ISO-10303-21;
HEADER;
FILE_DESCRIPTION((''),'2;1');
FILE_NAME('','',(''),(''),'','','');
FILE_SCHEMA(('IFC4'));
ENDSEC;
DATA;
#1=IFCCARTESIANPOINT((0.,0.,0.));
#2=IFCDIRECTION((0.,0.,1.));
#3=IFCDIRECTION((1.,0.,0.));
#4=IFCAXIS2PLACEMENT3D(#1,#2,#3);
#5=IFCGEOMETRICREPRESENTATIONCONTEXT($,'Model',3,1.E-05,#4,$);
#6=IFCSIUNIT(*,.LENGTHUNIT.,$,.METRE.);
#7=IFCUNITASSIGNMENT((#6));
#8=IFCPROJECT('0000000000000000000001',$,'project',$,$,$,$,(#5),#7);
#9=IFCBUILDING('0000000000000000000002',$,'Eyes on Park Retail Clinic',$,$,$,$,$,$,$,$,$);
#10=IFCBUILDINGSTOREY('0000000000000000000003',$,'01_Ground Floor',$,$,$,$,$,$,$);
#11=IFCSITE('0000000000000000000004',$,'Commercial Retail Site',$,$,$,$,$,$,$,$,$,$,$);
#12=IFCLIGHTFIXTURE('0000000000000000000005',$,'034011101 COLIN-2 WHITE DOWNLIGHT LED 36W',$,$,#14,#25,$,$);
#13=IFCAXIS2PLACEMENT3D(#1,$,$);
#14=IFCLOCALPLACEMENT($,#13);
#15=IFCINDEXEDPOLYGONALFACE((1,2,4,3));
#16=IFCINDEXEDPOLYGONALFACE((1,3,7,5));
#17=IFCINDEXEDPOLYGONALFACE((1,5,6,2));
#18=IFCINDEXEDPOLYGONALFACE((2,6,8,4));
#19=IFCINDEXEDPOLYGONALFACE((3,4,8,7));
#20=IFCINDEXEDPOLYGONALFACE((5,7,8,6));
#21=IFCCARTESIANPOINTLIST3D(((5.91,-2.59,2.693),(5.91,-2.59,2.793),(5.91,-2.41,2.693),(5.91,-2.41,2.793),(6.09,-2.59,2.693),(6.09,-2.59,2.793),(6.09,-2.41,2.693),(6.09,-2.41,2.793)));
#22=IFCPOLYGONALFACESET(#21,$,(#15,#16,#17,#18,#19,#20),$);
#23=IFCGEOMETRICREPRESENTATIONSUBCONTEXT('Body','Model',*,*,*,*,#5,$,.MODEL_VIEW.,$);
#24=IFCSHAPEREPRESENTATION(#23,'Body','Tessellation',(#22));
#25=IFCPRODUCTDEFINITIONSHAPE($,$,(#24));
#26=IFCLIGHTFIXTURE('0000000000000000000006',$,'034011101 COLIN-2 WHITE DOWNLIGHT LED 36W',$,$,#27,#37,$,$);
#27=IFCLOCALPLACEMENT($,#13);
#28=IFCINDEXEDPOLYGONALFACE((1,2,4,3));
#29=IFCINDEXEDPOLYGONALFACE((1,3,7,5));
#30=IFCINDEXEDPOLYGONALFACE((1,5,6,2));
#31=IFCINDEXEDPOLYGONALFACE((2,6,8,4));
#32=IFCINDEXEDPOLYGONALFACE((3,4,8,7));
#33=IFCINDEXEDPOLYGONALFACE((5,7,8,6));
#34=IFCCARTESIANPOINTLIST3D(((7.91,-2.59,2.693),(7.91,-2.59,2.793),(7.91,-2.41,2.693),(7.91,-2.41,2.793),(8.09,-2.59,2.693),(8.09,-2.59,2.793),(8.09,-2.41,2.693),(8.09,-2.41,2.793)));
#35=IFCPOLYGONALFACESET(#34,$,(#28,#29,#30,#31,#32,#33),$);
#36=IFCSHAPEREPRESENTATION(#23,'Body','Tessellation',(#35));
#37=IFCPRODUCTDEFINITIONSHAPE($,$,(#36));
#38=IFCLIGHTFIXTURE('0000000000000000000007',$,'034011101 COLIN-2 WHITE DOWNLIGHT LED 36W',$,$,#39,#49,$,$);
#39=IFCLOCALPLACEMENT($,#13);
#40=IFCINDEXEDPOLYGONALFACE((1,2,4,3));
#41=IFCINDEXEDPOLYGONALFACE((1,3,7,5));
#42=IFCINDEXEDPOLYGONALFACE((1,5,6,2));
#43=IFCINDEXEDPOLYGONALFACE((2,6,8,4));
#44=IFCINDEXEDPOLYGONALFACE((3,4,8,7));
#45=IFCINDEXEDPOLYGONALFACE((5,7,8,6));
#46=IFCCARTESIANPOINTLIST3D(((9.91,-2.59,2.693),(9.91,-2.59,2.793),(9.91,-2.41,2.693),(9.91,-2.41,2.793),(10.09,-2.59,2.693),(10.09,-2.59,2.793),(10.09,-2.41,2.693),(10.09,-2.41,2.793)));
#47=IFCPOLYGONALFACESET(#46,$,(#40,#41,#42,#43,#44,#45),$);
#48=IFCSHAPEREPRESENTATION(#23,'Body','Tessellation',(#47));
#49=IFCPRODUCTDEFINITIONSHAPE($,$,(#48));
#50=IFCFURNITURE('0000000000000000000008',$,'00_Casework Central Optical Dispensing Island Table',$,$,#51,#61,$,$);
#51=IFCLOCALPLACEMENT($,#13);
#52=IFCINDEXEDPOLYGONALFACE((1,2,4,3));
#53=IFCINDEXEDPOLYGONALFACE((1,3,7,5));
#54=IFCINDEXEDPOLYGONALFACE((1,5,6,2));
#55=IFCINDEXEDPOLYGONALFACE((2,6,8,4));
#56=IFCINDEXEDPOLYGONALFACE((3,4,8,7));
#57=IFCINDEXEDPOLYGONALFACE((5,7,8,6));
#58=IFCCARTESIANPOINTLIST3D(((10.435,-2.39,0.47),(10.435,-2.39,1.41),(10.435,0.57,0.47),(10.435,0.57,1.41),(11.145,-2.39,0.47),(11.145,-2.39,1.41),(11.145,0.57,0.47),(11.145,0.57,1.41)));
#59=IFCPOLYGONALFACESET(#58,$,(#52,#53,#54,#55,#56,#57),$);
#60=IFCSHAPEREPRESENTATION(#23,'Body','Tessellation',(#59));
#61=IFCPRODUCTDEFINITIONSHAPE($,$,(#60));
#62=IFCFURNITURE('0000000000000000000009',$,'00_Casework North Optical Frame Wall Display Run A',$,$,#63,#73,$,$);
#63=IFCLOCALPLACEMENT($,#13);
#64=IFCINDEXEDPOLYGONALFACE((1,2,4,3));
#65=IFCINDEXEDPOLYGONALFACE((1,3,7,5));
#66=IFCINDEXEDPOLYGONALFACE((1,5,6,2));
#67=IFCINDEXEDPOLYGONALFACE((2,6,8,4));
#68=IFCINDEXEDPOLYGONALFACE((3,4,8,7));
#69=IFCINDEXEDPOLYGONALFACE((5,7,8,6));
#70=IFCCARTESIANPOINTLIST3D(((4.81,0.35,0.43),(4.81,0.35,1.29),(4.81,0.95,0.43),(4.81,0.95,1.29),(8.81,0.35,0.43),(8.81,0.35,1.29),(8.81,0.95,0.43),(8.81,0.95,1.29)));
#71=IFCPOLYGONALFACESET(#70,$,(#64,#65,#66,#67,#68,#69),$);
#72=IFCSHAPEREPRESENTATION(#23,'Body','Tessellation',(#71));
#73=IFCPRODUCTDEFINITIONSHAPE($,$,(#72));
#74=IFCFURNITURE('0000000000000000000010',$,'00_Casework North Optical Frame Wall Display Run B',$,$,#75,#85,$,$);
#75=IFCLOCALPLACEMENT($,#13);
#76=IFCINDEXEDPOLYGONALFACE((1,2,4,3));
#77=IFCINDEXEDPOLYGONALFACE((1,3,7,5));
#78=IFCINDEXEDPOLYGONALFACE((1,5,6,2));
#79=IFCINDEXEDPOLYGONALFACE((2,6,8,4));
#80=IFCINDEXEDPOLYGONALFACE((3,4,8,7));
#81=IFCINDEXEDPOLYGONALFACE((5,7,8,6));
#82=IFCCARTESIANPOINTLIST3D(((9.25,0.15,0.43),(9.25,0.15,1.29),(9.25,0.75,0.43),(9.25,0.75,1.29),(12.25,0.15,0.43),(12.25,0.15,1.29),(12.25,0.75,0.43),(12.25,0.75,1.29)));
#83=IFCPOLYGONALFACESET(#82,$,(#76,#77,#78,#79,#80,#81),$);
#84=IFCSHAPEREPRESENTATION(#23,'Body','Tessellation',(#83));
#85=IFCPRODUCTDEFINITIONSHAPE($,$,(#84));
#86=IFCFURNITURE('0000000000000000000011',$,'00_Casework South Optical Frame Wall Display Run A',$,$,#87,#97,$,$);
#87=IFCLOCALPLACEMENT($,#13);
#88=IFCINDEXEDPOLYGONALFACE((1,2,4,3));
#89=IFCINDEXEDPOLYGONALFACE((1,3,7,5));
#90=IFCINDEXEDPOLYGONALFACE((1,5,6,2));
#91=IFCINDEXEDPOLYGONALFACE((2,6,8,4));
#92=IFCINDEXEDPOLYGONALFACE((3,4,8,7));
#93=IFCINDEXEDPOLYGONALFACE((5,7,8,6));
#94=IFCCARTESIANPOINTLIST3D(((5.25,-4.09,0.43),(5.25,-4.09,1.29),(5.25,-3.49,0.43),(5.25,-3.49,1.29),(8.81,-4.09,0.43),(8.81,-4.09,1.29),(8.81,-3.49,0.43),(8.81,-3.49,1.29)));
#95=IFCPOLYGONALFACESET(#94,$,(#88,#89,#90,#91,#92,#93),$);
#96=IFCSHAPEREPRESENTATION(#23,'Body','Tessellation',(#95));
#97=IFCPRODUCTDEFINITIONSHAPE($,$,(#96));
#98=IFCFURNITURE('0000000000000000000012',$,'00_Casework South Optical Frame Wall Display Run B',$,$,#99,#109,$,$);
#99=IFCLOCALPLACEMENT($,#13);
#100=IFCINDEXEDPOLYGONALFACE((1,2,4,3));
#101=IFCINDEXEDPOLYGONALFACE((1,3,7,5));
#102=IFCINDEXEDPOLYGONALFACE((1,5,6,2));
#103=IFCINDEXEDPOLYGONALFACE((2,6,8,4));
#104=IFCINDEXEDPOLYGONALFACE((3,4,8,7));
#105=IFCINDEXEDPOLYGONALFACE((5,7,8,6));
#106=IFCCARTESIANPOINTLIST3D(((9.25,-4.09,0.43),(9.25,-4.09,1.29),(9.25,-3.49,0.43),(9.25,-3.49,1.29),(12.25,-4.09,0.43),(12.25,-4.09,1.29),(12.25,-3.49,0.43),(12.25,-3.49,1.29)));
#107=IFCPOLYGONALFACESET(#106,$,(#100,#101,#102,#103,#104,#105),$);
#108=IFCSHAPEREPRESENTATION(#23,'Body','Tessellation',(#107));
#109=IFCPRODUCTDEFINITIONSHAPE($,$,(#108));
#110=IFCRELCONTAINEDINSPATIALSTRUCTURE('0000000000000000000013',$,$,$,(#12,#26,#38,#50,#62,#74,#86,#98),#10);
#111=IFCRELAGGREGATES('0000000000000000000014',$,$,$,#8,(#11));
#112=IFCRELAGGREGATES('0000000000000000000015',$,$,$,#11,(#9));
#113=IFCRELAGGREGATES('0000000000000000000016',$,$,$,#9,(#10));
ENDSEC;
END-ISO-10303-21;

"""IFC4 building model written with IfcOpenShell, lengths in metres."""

from ifc_helpers import new_model, si_unit, frame, origin, origin_with_axes, place, context, subcontext, project, spatial, rectangle, extrude, element, save


model = new_model("IFC4")

# Units and contexts
model_context = context("Model", 3, precision=1e-05, world=origin_with_axes())
body_context = subcontext(model_context, "Body", "Model", "MODEL_VIEW")
ifc_project = project(units=[si_unit("LENGTHUNIT", "METRE")], contexts=[model_context])

# Site, building, storey
site = spatial("IfcSite", under=ifc_project, Name="Commercial Retail Site")
building = spatial("IfcBuilding", under=site, Name="Eyes on Park Retail Clinic")
storey = spatial("IfcBuildingStorey", under=building, Name="01_Ground Floor")

# Light fixtures
for number, where, z_axis, x_axis, name in (
    (1, (6.0, -2.5, 2.693), (0.0, 0.0, 1.0), (1.0, 0.0, 0.0), "034011101 COLIN-2 WHITE DOWNLIGHT LED 36W"),
    (2, (8.0, -2.5, 2.693), (0.0, 0.0, 1.0), (1.0, 0.0, 0.0), "034011101 COLIN-2 WHITE DOWNLIGHT LED 36W"),
    (3, (10.0, -2.5, 2.693), (0.0, 0.0, 1.0), (1.0, 0.0, 0.0), "034011101 COLIN-2 WHITE DOWNLIGHT LED 36W"),
):
    element("IfcLightFixture", number, at=place(None, frame(where, z_axis=z_axis, x_axis=x_axis)), inside=storey, Name=name, context=body_context, shape_type="SweptSolid", body=[
        extrude(rectangle(XDim=0.18, YDim=0.18), origin(), (0.0, 0.0, 1.0), 0.1),
    ])

# Furniture
furniture_1_placement = place(None, frame((10.79, -0.91, 0.47), z_axis=(0.0, 0.0, 1.0), x_axis=(1.0, 0.0, 0.0)))
element("IfcFurniture", 4, at=furniture_1_placement, inside=storey, Name="00_Casework Central Optical Dispensing Island Table", context=body_context, shape_type="SweptSolid", body=[
    extrude(rectangle(XDim=0.71, YDim=2.96), origin(), (0.0, 0.0, 1.0), 0.94),
])
furniture_2_placement = place(None, frame((6.81, 0.65, 0.43), z_axis=(0.0, 0.0, 1.0), x_axis=(1.0, 0.0, 0.0)))
element("IfcFurniture", 5, at=furniture_2_placement, inside=storey, Name="00_Casework North Optical Frame Wall Display Run A", context=body_context, shape_type="SweptSolid", body=[
    extrude(rectangle(XDim=4.0, YDim=0.6), origin(), (0.0, 0.0, 1.0), 0.86),
])
furniture_3_placement = place(None, frame((10.75, 0.45, 0.43), z_axis=(0.0, 0.0, 1.0), x_axis=(1.0, 0.0, 0.0)))
element("IfcFurniture", 6, at=furniture_3_placement, inside=storey, Name="00_Casework North Optical Frame Wall Display Run B", context=body_context, shape_type="SweptSolid", body=[
    extrude(rectangle(XDim=3.0, YDim=0.6), origin(), (0.0, 0.0, 1.0), 0.86),
])
furniture_4_placement = place(None, frame((7.03, -3.79, 0.43), z_axis=(0.0, 0.0, 1.0), x_axis=(1.0, 0.0, 0.0)))
element("IfcFurniture", 7, at=furniture_4_placement, inside=storey, Name="00_Casework South Optical Frame Wall Display Run A", context=body_context, shape_type="SweptSolid", body=[
    extrude(rectangle(XDim=3.56, YDim=0.6), origin(), (0.0, 0.0, 1.0), 0.86),
])
furniture_5_placement = place(None, frame((10.75, -3.79, 0.43), z_axis=(0.0, 0.0, 1.0), x_axis=(1.0, 0.0, 0.0)))
element("IfcFurniture", 8, at=furniture_5_placement, inside=storey, Name="00_Casework South Optical Frame Wall Display Run B", context=body_context, shape_type="SweptSolid", body=[
    extrude(rectangle(XDim=3.0, YDim=0.6), origin(), (0.0, 0.0, 1.0), 0.86),
])

save(model, "model.ifc")
